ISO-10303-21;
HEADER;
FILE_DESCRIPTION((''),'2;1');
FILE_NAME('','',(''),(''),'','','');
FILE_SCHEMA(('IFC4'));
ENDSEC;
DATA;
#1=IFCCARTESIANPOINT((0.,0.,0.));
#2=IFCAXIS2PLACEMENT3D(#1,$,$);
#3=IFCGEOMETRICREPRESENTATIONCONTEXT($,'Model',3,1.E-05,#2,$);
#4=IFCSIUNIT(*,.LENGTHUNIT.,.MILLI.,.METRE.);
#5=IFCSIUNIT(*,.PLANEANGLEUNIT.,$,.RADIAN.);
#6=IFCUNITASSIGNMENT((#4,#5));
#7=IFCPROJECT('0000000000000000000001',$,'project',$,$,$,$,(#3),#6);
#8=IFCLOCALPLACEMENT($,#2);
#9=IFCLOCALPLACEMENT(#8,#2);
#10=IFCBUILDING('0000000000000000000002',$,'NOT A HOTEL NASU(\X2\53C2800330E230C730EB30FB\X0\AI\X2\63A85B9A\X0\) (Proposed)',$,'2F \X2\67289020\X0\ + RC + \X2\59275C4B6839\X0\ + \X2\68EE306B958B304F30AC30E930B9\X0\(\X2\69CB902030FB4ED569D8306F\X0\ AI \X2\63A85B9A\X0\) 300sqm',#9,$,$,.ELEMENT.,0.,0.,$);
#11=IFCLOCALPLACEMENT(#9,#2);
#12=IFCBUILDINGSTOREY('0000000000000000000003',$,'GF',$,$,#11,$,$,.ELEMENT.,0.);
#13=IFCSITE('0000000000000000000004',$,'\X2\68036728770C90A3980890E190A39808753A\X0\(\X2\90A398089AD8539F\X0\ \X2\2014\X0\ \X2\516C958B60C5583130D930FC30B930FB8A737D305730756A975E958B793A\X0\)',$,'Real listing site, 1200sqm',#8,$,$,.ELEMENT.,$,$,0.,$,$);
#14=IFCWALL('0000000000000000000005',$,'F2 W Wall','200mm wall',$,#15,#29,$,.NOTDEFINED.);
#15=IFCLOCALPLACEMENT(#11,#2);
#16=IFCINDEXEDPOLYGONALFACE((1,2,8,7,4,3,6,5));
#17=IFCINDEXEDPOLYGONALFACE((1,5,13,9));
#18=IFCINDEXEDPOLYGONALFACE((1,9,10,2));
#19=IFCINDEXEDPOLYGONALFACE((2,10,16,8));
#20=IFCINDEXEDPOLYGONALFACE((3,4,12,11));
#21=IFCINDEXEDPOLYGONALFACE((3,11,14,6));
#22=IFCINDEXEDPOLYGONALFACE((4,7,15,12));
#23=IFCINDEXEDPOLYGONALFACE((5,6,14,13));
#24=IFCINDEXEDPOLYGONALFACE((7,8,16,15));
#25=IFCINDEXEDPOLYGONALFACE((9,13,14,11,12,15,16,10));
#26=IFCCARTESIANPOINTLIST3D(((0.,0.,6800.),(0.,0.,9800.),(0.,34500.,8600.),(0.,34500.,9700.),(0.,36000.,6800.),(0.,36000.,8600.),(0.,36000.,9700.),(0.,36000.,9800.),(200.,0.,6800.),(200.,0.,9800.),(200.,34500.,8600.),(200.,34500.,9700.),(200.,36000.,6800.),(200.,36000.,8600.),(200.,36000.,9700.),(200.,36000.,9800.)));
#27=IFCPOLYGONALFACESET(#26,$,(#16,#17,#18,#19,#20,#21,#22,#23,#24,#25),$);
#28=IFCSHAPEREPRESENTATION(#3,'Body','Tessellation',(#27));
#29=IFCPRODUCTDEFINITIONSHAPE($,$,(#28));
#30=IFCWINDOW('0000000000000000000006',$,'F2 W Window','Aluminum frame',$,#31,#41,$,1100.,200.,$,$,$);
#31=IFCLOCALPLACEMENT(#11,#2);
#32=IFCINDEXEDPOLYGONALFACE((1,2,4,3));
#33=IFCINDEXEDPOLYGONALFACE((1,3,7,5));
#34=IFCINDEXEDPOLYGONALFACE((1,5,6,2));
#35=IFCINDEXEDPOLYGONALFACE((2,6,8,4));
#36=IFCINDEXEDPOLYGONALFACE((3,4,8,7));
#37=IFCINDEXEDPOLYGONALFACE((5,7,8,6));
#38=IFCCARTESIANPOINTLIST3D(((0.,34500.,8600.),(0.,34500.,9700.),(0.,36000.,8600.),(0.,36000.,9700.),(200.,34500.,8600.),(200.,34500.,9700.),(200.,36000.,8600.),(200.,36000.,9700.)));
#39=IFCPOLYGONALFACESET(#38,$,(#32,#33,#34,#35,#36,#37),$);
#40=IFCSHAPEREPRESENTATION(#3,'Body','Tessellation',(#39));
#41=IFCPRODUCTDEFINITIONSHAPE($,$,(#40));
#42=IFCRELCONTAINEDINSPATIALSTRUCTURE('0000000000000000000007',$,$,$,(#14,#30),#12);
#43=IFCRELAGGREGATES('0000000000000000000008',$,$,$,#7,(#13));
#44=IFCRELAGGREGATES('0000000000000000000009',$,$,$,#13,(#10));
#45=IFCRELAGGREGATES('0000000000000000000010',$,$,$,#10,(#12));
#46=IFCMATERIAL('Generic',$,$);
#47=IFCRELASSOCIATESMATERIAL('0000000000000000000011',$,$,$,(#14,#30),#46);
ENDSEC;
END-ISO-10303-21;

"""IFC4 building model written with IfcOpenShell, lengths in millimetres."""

from ifc_helpers import new_model, si_unit, frame, frame_2d, origin, place, context, project, spatial, rectangle, extrude, material, element, fill, save


model = new_model("IFC4")

# Units and contexts
model_context = context("Model", 3, precision=1e-05, world=origin())
ifc_project = project(units=[si_unit("LENGTHUNIT", "METRE", prefix="MILLI"), si_unit("PLANEANGLEUNIT", "RADIAN")], contexts=[model_context])

# Site, building, storey
site_placement = place(None, origin())
site = spatial("IfcSite", under=ifc_project, at=site_placement, Name="栃木県那須郡那須町(那須高原 — 公開情報ベース・詳細地番非開示)", ObjectType="Real listing site, 1200sqm", CompositionType="ELEMENT", RefElevation=0.0)
building_placement = place(site_placement, origin())
building = spatial("IfcBuilding", under=site, at=building_placement, Name="NOT A HOTEL NASU(参考モデル・AI推定) (Proposed)", ObjectType="2F 木造 + RC + 大屋根 + 森に開くガラス(構造・仕様は AI 推定) 300sqm", CompositionType="ELEMENT", ElevationOfRefHeight=0.0, ElevationOfTerrain=0.0)
storey_placement = place(building_placement, origin())
storey = spatial("IfcBuildingStorey", under=building, at=storey_placement, Name="GF", CompositionType="ELEMENT", Elevation=0.0)

# Shared definitions
ifc_material_1 = material(Name="Generic")

# Wall, opening, window
wall_1_placement = place(storey_placement, frame((0.0, 0.0, 3400.0)))
wall_1 = element("IfcWall", 1, at=wall_1_placement, inside=storey, material=ifc_material_1, Name="F2 W Wall", Description="200mm wall", PredefinedType="NOTDEFINED", context=model_context, shape_type="SweptSolid", body=[
    extrude(rectangle(XDim=200.0, YDim=36000.0, at=frame_2d((100.0, 18000.0))), frame((0.0, 0.0, 3400.0)), (0.0, 0.0, 1.0), 3000.0),
])
opening_1_placement = place(storey_placement, frame((0.0, 17250.0, 4300.0)))
opening_1 = element("IfcOpeningElement", 2, at=opening_1_placement, cuts=wall_1, PredefinedType="NOTDEFINED", context=model_context, shape_type="SweptSolid", body=[
    extrude(rectangle(XDim=200.0, YDim=1500.0, at=frame_2d((100.0, 750.0))), frame((0.0, 17250.0, 4300.0)), (0.0, 0.0, 1.0), 1100.0),
])
window_1_placement = place(storey_placement, frame((0.0, 17250.0, 4300.0)))
window_1 = element("IfcWindow", 3, at=window_1_placement, inside=storey, material=ifc_material_1, Name="F2 W Window", Description="Aluminum frame", OverallHeight=1100.0, OverallWidth=200.0, context=model_context, shape_type="SweptSolid", body=[
    extrude(rectangle(XDim=200.0, YDim=1500.0, at=frame_2d((100.0, 750.0))), frame((0.0, 17250.0, 4300.0)), (0.0, 0.0, 1.0), 1100.0),
])
fill(opening_1, window_1)

save(model, "model.ifc")
